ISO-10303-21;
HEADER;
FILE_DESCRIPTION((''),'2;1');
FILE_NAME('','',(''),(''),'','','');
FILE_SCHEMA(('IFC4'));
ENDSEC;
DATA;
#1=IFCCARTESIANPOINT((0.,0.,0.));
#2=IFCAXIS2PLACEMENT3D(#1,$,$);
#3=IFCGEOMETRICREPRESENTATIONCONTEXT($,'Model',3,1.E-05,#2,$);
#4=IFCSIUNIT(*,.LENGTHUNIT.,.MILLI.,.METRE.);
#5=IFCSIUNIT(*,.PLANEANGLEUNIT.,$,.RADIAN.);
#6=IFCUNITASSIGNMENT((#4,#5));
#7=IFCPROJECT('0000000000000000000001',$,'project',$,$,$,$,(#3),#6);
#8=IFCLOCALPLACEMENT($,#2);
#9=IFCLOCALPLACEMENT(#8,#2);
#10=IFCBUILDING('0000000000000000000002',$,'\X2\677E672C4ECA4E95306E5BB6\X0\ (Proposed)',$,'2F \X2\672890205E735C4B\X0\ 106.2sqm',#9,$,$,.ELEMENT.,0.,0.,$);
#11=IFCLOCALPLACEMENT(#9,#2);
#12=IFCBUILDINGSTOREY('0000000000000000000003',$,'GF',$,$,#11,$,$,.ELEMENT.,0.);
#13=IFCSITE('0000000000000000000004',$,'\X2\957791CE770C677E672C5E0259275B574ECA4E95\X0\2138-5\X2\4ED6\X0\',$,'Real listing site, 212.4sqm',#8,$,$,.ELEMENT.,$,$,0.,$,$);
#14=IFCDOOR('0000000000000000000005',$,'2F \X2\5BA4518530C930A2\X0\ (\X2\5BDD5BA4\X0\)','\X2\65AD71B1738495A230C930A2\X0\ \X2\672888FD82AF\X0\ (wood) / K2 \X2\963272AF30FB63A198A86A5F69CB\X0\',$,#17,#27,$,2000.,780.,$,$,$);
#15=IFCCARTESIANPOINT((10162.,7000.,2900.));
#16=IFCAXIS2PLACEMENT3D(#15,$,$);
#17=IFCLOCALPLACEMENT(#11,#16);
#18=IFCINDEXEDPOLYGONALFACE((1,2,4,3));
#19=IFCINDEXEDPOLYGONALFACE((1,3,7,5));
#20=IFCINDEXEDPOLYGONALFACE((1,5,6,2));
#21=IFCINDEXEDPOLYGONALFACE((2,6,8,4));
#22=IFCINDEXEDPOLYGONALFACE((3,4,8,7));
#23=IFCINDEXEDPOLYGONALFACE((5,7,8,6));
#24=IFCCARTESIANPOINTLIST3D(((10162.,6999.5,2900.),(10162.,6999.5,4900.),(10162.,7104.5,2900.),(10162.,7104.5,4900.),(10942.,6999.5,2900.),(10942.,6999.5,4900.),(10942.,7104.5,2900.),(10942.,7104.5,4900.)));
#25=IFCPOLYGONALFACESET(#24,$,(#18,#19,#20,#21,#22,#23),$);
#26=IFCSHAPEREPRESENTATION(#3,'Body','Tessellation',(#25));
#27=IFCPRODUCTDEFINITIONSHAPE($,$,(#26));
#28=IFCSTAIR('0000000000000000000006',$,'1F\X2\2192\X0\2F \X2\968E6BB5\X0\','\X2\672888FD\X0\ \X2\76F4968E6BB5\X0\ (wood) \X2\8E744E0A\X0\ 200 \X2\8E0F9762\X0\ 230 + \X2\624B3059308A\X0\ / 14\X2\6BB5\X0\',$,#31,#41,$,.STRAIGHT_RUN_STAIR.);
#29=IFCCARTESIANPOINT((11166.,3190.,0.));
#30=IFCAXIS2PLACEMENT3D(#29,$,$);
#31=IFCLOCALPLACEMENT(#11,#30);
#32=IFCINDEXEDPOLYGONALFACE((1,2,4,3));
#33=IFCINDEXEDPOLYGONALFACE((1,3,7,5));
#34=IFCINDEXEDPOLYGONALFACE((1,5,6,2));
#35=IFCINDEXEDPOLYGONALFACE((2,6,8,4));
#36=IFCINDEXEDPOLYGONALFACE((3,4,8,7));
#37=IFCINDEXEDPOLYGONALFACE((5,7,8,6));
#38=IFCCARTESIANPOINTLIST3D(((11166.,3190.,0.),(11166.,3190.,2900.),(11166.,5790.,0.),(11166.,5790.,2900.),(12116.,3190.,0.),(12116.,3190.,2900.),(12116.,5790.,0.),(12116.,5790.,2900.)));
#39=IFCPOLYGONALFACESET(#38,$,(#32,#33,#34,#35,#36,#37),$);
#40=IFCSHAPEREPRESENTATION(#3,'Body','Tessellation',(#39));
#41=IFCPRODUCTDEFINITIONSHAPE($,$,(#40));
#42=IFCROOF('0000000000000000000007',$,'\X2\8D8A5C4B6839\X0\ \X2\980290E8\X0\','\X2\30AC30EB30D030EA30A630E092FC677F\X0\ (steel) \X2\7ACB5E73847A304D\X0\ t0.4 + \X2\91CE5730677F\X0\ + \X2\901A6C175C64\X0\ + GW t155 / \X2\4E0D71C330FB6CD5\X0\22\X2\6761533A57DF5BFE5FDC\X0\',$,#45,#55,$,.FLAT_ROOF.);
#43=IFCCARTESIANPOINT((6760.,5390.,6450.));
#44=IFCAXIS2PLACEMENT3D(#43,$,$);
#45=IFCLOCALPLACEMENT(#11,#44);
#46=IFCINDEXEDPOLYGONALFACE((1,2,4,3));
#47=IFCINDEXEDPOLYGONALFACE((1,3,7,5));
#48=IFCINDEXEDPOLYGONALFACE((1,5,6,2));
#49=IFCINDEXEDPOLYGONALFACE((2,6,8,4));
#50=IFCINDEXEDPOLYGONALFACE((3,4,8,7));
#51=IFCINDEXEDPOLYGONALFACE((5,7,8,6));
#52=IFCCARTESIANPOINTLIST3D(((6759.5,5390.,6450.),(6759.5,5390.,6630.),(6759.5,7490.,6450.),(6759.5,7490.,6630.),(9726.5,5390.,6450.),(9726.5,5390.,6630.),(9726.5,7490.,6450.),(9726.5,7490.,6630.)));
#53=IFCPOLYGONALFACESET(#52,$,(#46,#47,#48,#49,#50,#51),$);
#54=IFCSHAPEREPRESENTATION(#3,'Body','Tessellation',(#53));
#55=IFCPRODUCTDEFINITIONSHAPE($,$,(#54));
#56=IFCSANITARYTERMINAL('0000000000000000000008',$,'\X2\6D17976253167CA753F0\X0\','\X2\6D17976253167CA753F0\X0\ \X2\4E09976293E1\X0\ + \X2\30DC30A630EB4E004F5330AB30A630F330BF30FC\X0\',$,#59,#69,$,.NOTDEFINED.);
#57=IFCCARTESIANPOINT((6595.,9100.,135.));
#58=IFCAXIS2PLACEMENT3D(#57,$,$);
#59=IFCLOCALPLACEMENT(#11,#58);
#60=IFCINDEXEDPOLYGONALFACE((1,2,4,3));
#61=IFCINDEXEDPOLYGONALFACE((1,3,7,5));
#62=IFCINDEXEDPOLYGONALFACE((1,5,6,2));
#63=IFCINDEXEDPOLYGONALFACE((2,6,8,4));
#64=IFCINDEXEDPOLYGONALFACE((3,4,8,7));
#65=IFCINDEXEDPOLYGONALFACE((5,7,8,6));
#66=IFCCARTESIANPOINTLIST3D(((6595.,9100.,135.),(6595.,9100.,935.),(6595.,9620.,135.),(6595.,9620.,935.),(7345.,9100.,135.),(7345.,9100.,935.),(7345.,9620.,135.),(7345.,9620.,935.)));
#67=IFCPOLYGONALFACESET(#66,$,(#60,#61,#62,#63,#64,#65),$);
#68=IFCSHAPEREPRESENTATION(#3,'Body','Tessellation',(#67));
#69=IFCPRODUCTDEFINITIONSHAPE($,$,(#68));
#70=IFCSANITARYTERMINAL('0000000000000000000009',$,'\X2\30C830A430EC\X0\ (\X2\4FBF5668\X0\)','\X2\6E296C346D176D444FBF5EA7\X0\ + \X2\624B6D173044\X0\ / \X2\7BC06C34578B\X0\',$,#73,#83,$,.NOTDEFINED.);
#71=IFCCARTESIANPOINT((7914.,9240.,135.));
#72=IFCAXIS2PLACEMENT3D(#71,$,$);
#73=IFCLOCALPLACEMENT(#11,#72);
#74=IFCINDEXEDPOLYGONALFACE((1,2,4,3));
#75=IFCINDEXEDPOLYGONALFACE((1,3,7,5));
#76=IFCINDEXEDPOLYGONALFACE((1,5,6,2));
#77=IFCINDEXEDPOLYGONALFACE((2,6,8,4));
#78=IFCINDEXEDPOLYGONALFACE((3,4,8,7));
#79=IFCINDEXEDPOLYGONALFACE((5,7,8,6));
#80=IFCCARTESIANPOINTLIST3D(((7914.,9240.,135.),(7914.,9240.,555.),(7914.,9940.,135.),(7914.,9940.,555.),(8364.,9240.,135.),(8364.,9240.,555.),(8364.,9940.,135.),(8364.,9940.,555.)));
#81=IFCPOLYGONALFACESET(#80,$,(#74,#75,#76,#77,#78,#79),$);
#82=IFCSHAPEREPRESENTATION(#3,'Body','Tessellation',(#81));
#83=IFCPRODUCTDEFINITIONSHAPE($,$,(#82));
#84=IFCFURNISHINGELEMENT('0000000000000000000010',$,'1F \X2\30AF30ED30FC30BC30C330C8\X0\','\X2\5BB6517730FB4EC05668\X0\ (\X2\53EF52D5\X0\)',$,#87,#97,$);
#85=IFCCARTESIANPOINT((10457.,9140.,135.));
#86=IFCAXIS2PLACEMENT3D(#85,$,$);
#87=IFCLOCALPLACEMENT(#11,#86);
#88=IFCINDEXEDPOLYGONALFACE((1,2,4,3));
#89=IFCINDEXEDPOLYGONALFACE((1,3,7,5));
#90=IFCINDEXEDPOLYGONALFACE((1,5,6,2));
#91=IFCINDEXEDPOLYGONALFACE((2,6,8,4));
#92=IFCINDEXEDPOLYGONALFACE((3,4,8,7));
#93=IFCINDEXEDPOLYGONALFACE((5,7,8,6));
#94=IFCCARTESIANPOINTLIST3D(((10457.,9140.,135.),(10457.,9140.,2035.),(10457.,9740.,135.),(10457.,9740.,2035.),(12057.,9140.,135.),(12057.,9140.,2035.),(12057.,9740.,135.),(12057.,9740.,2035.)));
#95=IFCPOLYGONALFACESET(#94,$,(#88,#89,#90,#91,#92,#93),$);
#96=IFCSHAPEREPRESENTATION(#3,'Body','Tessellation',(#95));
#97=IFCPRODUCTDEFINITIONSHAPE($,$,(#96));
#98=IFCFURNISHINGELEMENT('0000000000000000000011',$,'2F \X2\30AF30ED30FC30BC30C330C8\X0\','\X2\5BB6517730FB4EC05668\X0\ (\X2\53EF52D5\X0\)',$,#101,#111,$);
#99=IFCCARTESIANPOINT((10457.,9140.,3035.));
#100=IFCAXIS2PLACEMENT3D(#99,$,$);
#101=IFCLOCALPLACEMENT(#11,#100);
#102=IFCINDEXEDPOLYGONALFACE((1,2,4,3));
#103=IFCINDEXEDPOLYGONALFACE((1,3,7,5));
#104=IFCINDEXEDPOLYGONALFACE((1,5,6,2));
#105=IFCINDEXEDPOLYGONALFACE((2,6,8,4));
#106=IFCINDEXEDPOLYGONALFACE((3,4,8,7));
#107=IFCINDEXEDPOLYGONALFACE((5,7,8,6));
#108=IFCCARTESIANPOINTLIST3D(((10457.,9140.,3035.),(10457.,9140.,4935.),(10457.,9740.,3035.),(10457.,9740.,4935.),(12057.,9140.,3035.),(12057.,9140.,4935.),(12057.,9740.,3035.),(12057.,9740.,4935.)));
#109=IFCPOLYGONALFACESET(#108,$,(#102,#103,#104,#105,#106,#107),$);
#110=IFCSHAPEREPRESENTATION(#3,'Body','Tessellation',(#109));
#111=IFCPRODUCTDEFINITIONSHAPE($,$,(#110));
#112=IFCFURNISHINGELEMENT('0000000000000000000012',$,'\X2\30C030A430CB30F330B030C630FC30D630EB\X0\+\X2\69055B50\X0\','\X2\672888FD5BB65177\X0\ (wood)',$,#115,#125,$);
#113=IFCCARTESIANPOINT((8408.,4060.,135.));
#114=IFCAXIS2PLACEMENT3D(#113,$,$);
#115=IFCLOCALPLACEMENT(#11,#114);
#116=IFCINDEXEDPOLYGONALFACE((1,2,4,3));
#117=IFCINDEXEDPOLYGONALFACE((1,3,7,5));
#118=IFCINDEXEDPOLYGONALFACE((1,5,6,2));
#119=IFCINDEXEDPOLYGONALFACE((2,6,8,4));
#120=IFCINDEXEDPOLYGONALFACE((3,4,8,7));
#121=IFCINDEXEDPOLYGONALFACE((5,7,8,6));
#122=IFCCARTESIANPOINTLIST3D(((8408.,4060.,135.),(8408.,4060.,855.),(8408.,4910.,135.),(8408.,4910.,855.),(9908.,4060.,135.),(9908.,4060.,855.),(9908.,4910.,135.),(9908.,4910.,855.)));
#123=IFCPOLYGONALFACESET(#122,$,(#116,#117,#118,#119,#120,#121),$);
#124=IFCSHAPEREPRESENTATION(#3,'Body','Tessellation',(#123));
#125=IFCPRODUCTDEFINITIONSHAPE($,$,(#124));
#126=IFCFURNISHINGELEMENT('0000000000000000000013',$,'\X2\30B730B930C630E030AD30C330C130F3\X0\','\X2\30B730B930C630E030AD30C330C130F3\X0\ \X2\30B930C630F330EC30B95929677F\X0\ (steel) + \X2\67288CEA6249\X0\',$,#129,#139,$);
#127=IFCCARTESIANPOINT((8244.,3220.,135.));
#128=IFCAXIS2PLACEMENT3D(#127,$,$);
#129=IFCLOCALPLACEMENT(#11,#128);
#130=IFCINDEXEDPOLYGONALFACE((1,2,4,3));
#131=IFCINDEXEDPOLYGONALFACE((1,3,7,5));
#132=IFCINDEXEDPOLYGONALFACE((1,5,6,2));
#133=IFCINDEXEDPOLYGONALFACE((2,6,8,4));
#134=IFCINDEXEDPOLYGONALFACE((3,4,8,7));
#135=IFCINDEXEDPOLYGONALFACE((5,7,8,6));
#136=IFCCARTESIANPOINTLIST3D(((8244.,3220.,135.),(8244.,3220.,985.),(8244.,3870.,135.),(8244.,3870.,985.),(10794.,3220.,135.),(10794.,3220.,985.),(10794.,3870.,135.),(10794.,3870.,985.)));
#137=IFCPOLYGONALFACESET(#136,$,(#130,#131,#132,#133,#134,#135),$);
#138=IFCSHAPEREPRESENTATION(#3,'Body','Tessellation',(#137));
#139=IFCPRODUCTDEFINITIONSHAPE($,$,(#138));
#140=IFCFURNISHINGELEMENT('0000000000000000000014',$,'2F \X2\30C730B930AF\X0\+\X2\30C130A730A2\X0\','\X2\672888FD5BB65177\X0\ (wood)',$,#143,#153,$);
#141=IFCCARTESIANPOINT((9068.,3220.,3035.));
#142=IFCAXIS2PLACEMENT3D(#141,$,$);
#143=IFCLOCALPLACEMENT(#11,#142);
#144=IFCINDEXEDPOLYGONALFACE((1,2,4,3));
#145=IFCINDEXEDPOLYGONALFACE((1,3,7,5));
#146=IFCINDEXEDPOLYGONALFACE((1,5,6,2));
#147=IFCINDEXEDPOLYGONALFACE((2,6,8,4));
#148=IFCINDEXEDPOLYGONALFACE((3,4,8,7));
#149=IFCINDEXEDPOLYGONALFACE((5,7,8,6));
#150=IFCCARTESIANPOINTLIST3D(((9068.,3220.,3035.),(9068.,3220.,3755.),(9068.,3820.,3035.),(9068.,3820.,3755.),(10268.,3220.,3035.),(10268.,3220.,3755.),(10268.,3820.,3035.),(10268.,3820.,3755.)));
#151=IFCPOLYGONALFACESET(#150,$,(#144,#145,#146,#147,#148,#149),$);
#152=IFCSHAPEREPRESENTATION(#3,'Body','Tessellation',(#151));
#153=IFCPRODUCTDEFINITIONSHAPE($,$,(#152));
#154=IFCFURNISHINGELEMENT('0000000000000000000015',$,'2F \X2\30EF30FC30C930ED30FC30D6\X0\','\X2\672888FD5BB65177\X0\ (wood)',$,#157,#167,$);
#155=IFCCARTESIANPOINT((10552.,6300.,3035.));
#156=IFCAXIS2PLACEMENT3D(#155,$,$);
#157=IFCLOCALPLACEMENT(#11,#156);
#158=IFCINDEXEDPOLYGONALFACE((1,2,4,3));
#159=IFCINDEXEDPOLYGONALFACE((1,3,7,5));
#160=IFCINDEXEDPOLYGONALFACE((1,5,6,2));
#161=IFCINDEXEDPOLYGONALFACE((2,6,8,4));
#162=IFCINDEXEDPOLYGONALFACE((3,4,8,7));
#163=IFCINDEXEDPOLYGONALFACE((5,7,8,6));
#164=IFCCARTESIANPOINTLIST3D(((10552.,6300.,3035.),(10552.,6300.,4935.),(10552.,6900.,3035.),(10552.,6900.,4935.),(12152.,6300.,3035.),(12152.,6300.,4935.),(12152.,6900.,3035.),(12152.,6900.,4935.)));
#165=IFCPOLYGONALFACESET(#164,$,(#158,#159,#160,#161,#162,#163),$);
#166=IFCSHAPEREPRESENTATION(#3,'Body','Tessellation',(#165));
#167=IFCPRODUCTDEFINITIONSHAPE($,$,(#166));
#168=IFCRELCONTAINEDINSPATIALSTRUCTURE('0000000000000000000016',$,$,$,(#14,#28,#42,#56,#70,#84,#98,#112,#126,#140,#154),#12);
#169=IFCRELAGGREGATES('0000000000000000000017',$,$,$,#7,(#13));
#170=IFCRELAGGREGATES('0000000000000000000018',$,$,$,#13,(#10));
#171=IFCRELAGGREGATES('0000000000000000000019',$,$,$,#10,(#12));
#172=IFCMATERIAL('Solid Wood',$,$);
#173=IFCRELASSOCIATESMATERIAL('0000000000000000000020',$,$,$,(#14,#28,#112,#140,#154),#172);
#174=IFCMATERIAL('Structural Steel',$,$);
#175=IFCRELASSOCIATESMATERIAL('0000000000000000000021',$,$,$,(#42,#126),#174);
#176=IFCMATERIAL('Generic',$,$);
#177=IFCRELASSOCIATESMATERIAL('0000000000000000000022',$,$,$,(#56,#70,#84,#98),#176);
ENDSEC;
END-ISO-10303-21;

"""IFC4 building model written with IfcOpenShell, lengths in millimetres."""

from ifc_helpers import new_model, si_unit, frame, frame_2d, origin, place, context, project, spatial, rectangle, extrude, material, element, save


model = new_model("IFC4")

# Units and contexts
model_context = context("Model", 3, precision=1e-05, world=origin())
ifc_project = project(units=[si_unit("LENGTHUNIT", "METRE", prefix="MILLI"), si_unit("PLANEANGLEUNIT", "RADIAN")], contexts=[model_context])

# Site, building, storey
site_placement = place(None, origin())
site = spatial("IfcSite", under=ifc_project, at=site_placement, Name="長野県松本市大字今井2138-5他", ObjectType="Real listing site, 212.4sqm", CompositionType="ELEMENT", RefElevation=0.0)
building_placement = place(site_placement, origin())
building = spatial("IfcBuilding", under=site, at=building_placement, Name="松本今井の家 (Proposed)", ObjectType="2F 木造平屋 106.2sqm", CompositionType="ELEMENT", ElevationOfRefHeight=0.0, ElevationOfTerrain=0.0)
storey_placement = place(building_placement, origin())
storey = spatial("IfcBuildingStorey", under=building, at=storey_placement, Name="GF", CompositionType="ELEMENT", Elevation=0.0)

# Shared definitions
ifc_material_1 = material(Name="Solid Wood")

# Door
door_1_placement = place(storey_placement, frame((10162.0, 7000.0, 2900.0)))
element("IfcDoor", 1, at=door_1_placement, inside=storey, material=ifc_material_1, Name="2F 室内ドア (寝室)", Description="断熱玄関ドア 木製芯 (wood) / K2 防犯・採風機構", OverallHeight=2000.0, OverallWidth=780.0, context=model_context, shape_type="SweptSolid", body=[
    extrude(rectangle(XDim=780.0, YDim=105.0, at=frame_2d((390.0, 52.0))), frame((10162.0, 7000.0, 2900.0)), (0.0, 0.0, 1.0), 2000.0),
])

# Stair
stair_placement = place(storey_placement, frame((11166.0, 3190.0, 0.0)))
element("IfcStair", 2, at=stair_placement, inside=storey, material=ifc_material_1, Name="1F→2F 階段", Description="木製 直階段 (wood) 蹴上 200 踏面 230 + 手すり / 14段", PredefinedType="STRAIGHT_RUN_STAIR", context=model_context, shape_type="SweptSolid", body=[
    extrude(rectangle(XDim=950.0, YDim=2600.0, at=frame_2d((475.0, 1300.0))), frame((11166.0, 3190.0, 0.0)), (0.0, 0.0, 1.0), 2900.0),
])

# Roof
ifc_material_2 = material(Name="Structural Steel")
roof_placement = place(storey_placement, frame((6760.0, 5390.0, 6450.0)))
element("IfcRoof", 3, at=roof_placement, inside=storey, material=ifc_material_2, Name="越屋根 頂部", Description="ガルバリウム鋼板 (steel) 立平葺き t0.4 + 野地板 + 通気層 + GW t155 / 不燃・法22条区域対応", PredefinedType="FLAT_ROOF", context=model_context, shape_type="SweptSolid", body=[
    extrude(rectangle(XDim=2967.0, YDim=2100.0, at=frame_2d((1483.0, 1050.0))), frame((6760.0, 5390.0, 6450.0)), (0.0, 0.0, 1.0), 180.0),
])

# Sanitary terminals
ifc_material_3 = material(Name="Generic")
sanitary_terminal_1_placement = place(storey_placement, frame((6595.0, 9100.0, 135.0)))
element("IfcSanitaryTerminal", 4, at=sanitary_terminal_1_placement, inside=storey, material=ifc_material_3, Name="洗面化粧台", Description="洗面化粧台 三面鏡 + ボウル一体カウンター", PredefinedType="NOTDEFINED", context=model_context, shape_type="SweptSolid", body=[
    extrude(rectangle(XDim=750.0, YDim=520.0, at=frame_2d((375.0, 260.0))), frame((6595.0, 9100.0, 135.0)), (0.0, 0.0, 1.0), 800.0),
])
sanitary_terminal_2_placement = place(storey_placement, frame((7914.0, 9240.0, 135.0)))
element("IfcSanitaryTerminal", 5, at=sanitary_terminal_2_placement, inside=storey, material=ifc_material_3, Name="トイレ (便器)", Description="温水洗浄便座 + 手洗い / 節水型", PredefinedType="NOTDEFINED", context=model_context, shape_type="SweptSolid", body=[
    extrude(rectangle(XDim=450.0, YDim=700.0, at=frame_2d((225.0, 350.0))), frame((7914.0, 9240.0, 135.0)), (0.0, 0.0, 1.0), 420.0),
])

# Furnishing elements
furnishing_1_placement = place(storey_placement, frame((10457.0, 9140.0, 135.0)))
element("IfcFurnishingElement", 6, at=furnishing_1_placement, inside=storey, material=ifc_material_3, Name="1F クローゼット", Description="家具・什器 (可動)", context=model_context, shape_type="SweptSolid", body=[
    extrude(rectangle(XDim=1600.0, YDim=600.0, at=frame_2d((800.0, 300.0))), frame((10457.0, 9140.0, 135.0)), (0.0, 0.0, 1.0), 1900.0),
])
furnishing_2_placement = place(storey_placement, frame((10457.0, 9140.0, 3035.0)))
element("IfcFurnishingElement", 7, at=furnishing_2_placement, inside=storey, material=ifc_material_3, Name="2F クローゼット", Description="家具・什器 (可動)", context=model_context, shape_type="SweptSolid", body=[
    extrude(rectangle(XDim=1600.0, YDim=600.0, at=frame_2d((800.0, 300.0))), frame((10457.0, 9140.0, 3035.0)), (0.0, 0.0, 1.0), 1900.0),
])
furnishing_3_placement = place(storey_placement, frame((8408.0, 4060.0, 135.0)))
element("IfcFurnishingElement", 8, at=furnishing_3_placement, inside=storey, material=ifc_material_1, Name="ダイニングテーブル+椅子", Description="木製家具 (wood)", context=model_context, shape_type="SweptSolid", body=[
    extrude(rectangle(XDim=1500.0, YDim=850.0, at=frame_2d((750.0, 425.0))), frame((8408.0, 4060.0, 135.0)), (0.0, 0.0, 1.0), 720.0),
])
furnishing_4_placement = place(storey_placement, frame((8244.0, 3220.0, 135.0)))
element("IfcFurnishingElement", 9, at=furnishing_4_placement, inside=storey, material=ifc_material_2, Name="システムキッチン", Description="システムキッチン ステンレス天板 (steel) + 木質扉", context=model_context, shape_type="SweptSolid", body=[
    extrude(rectangle(XDim=2550.0, YDim=650.0, at=frame_2d((1275.0, 325.0))), frame((8244.0, 3220.0, 135.0)), (0.0, 0.0, 1.0), 850.0),
])
furnishing_5_placement = place(storey_placement, frame((9068.0, 3220.0, 3035.0)))
element("IfcFurnishingElement", 10, at=furnishing_5_placement, inside=storey, material=ifc_material_1, Name="2F デスク+チェア", Description="木製家具 (wood)", context=model_context, shape_type="SweptSolid", body=[
    extrude(rectangle(XDim=1200.0, YDim=600.0, at=frame_2d((600.0, 300.0))), frame((9068.0, 3220.0, 3035.0)), (0.0, 0.0, 1.0), 720.0),
])
furnishing_6_placement = place(storey_placement, frame((10552.0, 6300.0, 3035.0)))
element("IfcFurnishingElement", 11, at=furnishing_6_placement, inside=storey, material=ifc_material_1, Name="2F ワードローブ", Description="木製家具 (wood)", context=model_context, shape_type="SweptSolid", body=[
    extrude(rectangle(XDim=1600.0, YDim=600.0, at=frame_2d((800.0, 300.0))), frame((10552.0, 6300.0, 3035.0)), (0.0, 0.0, 1.0), 1900.0),
])

save(model, "model.ifc")
